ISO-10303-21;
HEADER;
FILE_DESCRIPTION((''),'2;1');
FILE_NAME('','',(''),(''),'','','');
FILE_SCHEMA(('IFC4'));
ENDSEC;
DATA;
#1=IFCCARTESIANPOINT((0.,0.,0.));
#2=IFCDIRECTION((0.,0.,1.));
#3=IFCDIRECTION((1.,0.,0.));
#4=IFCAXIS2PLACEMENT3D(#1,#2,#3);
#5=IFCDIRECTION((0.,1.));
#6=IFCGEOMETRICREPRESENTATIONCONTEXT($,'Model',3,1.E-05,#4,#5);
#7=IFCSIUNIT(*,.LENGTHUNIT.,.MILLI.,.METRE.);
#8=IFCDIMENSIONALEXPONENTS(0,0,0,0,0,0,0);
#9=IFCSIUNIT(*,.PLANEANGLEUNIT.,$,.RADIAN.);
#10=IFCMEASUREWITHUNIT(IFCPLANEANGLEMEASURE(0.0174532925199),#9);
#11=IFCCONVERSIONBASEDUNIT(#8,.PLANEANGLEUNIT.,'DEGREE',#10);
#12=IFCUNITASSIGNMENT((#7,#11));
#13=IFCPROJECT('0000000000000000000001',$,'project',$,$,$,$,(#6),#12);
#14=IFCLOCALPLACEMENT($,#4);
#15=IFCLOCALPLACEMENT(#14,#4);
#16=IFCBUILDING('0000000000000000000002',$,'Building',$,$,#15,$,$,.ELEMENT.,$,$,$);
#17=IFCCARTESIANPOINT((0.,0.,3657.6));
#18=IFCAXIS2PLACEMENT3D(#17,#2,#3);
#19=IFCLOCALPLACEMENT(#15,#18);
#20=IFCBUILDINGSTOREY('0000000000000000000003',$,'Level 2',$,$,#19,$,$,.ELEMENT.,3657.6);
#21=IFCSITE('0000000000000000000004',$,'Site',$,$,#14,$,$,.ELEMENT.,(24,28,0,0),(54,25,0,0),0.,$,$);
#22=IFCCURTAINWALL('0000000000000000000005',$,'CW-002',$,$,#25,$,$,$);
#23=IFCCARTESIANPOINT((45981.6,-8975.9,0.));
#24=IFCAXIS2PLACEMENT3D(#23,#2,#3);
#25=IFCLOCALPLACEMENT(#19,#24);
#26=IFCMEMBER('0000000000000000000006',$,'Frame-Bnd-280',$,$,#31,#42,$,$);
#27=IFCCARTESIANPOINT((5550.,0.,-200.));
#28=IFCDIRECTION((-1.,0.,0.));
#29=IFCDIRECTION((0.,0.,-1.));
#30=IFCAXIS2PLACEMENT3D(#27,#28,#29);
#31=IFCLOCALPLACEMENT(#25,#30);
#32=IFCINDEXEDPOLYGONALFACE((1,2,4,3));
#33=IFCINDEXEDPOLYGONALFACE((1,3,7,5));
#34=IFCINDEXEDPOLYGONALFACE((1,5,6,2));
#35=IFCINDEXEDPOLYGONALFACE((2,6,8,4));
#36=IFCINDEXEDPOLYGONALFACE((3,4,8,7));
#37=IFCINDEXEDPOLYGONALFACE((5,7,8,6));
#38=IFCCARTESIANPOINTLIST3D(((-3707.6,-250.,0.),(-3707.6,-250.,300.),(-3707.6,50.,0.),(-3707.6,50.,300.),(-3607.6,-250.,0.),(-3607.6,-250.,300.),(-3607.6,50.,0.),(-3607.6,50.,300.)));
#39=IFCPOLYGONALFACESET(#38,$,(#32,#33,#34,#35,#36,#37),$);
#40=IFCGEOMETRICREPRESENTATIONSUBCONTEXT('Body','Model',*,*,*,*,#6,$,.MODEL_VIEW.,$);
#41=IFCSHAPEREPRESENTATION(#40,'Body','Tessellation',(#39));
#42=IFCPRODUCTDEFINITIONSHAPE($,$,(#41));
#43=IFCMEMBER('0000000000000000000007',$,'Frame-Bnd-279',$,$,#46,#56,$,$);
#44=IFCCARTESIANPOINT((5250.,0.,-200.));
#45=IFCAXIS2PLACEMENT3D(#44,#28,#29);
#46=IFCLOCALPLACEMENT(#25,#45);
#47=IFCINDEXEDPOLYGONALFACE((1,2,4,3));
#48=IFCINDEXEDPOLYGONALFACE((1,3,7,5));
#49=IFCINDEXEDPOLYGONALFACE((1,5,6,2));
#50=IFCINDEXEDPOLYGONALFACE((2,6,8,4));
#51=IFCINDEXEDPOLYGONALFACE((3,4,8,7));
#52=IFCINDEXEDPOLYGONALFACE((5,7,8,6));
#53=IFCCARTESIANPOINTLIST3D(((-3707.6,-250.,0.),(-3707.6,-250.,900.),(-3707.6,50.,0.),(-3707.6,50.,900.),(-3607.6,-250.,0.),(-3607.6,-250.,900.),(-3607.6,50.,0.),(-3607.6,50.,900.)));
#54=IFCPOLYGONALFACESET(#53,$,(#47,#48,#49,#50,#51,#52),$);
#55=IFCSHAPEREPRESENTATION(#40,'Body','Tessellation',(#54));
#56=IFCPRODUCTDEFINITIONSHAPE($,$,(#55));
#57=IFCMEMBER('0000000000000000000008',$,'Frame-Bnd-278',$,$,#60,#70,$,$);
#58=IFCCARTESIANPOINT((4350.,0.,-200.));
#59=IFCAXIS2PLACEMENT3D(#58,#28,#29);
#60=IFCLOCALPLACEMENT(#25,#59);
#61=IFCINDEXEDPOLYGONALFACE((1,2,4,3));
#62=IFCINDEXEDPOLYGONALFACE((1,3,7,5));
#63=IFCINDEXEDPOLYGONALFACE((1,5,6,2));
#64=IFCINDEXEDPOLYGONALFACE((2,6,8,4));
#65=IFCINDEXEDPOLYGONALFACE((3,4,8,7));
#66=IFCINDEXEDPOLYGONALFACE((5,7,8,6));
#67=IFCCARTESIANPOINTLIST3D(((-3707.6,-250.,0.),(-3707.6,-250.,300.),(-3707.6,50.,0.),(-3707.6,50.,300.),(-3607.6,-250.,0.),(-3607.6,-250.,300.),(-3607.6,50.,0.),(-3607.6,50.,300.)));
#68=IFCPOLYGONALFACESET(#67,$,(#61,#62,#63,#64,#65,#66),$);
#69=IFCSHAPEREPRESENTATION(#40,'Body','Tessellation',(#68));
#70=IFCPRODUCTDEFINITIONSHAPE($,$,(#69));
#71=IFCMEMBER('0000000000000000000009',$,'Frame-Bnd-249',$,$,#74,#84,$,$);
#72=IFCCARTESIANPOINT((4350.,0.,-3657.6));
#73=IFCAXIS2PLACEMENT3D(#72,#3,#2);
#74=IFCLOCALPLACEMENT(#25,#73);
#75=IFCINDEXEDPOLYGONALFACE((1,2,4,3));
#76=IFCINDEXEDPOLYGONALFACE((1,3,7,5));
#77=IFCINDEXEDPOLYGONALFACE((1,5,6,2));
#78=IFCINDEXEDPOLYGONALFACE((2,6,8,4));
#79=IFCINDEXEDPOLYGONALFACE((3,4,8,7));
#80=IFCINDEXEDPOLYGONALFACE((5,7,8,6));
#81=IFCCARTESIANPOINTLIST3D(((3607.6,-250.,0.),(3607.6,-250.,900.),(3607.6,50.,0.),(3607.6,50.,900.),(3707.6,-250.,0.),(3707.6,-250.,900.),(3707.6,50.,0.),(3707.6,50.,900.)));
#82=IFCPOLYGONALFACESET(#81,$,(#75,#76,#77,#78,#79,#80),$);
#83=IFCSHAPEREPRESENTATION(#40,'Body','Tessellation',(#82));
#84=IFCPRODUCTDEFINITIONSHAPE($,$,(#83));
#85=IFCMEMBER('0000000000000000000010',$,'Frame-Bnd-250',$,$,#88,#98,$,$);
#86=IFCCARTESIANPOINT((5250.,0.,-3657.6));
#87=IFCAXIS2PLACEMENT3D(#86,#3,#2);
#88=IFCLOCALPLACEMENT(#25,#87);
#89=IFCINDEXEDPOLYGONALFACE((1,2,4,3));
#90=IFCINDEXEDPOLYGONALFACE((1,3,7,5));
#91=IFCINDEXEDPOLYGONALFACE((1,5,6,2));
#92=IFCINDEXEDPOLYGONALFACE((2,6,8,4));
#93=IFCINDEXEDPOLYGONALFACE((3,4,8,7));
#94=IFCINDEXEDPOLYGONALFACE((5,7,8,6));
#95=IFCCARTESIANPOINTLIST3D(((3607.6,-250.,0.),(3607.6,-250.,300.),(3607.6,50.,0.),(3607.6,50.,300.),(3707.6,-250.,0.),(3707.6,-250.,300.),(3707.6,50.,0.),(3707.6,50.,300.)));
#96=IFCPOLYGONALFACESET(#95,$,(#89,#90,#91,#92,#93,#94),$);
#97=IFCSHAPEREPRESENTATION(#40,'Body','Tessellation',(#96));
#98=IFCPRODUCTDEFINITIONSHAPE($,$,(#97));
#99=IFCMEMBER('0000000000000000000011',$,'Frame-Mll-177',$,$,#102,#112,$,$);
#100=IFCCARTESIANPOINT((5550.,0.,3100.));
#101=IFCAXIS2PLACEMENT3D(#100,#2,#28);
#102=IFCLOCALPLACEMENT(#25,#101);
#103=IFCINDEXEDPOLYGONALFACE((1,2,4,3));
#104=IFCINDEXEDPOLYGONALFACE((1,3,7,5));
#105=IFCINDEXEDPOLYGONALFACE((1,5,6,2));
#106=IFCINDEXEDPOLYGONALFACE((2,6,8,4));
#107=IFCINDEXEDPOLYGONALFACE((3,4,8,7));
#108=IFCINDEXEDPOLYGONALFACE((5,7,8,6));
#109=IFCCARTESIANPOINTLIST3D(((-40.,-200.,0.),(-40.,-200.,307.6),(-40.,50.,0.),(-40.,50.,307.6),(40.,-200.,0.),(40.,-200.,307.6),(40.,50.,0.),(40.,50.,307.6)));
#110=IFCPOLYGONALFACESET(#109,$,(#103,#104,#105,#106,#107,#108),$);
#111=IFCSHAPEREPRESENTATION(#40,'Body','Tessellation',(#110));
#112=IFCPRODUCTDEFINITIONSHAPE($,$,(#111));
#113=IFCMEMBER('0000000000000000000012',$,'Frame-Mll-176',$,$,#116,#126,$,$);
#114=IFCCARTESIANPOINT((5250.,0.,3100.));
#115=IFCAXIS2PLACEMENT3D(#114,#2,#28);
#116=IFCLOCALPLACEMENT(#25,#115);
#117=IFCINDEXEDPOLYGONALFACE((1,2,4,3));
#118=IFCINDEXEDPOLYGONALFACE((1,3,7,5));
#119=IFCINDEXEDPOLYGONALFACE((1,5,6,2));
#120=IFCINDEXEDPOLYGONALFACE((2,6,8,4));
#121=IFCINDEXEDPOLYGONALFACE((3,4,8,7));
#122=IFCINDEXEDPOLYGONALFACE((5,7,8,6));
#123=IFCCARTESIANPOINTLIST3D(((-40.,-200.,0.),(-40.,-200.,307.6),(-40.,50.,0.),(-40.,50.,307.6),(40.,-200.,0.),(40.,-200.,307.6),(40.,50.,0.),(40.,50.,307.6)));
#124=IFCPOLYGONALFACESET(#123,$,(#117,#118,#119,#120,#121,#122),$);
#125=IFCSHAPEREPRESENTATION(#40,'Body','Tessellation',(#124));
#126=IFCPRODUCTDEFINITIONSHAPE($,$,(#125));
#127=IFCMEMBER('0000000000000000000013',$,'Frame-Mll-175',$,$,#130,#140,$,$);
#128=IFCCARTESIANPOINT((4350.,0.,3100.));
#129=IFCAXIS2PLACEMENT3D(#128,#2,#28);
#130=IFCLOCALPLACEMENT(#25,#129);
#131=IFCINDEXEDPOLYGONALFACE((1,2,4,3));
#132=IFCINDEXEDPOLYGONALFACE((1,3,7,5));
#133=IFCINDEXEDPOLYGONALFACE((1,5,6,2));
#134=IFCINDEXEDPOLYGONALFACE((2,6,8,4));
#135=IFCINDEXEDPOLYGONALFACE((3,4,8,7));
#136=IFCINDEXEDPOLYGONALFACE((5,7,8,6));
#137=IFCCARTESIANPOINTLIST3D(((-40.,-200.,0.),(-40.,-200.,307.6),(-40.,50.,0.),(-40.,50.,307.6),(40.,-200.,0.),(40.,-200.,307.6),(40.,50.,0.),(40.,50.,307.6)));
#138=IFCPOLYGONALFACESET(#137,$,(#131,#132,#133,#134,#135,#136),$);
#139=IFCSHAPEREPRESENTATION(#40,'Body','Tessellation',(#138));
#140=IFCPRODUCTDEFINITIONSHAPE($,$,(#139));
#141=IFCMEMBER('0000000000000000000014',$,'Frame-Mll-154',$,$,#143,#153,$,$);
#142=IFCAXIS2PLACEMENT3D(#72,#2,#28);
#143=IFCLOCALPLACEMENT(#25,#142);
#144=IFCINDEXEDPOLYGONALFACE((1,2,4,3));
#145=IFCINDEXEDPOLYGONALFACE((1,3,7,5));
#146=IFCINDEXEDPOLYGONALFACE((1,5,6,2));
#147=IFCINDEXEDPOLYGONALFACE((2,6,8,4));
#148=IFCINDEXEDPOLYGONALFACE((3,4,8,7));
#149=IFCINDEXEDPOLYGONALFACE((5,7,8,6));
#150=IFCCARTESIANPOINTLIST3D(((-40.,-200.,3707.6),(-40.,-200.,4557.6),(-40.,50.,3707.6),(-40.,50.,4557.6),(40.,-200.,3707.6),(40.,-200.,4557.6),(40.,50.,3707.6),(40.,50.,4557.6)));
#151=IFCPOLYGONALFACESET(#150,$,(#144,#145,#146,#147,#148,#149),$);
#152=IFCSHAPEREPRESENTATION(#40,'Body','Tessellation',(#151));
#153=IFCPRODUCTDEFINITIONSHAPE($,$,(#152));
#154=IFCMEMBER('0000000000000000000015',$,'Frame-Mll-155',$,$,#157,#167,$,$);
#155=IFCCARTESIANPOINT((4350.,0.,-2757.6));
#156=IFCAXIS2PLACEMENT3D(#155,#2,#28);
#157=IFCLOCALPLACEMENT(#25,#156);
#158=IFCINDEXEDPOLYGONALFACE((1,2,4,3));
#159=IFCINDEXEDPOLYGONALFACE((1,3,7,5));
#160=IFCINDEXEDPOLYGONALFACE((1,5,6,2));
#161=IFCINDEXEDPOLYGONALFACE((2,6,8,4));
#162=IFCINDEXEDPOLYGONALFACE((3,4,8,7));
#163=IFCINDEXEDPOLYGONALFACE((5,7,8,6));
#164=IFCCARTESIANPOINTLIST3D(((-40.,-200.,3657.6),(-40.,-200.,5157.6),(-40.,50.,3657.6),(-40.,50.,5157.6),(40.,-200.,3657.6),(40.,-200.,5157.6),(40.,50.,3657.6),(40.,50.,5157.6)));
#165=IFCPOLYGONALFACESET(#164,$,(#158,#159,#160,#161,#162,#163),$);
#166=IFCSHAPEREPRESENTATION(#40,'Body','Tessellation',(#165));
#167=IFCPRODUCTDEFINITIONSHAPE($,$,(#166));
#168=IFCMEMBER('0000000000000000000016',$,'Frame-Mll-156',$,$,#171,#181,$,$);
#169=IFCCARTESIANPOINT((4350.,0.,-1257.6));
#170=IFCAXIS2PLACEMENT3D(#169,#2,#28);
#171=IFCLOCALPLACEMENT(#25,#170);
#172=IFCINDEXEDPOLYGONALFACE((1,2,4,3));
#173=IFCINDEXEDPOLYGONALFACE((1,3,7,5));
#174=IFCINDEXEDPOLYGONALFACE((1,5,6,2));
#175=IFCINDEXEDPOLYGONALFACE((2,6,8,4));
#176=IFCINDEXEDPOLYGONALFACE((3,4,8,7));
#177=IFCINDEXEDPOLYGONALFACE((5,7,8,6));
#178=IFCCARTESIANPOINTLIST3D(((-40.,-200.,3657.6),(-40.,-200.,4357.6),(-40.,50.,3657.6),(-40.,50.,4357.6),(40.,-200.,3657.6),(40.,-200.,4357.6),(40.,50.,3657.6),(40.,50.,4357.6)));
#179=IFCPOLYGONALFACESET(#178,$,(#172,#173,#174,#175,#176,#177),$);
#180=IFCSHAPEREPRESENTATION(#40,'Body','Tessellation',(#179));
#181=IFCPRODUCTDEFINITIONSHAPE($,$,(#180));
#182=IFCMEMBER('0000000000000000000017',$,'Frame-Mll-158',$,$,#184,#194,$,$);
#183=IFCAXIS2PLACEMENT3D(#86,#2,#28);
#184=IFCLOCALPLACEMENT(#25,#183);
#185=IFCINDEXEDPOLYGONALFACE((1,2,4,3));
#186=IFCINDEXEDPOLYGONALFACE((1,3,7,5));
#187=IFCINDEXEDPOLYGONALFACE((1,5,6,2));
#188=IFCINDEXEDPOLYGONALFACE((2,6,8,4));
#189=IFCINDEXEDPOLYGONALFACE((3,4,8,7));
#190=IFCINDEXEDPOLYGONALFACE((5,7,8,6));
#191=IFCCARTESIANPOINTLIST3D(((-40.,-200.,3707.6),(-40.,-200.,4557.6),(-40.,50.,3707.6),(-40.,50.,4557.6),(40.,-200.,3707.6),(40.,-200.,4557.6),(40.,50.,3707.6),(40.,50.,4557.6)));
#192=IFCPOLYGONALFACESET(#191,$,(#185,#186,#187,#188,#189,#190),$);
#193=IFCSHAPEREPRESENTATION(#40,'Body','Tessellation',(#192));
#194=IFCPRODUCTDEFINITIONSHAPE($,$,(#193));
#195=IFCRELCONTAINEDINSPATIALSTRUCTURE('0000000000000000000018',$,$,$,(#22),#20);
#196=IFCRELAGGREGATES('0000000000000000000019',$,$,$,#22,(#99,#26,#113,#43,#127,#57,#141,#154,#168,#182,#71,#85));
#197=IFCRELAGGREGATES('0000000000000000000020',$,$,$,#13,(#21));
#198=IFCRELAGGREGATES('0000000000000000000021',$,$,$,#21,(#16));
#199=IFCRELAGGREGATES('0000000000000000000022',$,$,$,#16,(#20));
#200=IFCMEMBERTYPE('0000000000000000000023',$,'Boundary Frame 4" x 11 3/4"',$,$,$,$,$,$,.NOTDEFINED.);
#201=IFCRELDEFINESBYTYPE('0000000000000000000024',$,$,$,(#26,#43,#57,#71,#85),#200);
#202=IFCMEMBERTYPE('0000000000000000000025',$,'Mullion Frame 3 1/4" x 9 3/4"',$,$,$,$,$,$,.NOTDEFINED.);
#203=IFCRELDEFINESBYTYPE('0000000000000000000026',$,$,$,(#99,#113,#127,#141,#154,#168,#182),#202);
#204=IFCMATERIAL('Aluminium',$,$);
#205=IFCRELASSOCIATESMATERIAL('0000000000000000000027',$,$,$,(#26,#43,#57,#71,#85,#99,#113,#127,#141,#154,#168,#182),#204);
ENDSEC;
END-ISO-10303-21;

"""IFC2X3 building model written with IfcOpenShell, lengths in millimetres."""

from ifc_helpers import new_model, entity, si_unit, converted_unit, direction, frame, origin_with_axes, place, context, subcontext, project, spatial, polyline, outline, extrude, material, type_object, element, aggregate, save


model = new_model("IFC2X3")

# Units and contexts
model_context = context("Model", 3, precision=1e-05, world=origin_with_axes(), true_north=direction((0.0, 1.0)))
body_context = subcontext(model_context, "Body", "Model", "MODEL_VIEW")
ifc_project = project(units=[si_unit("LENGTHUNIT", "METRE", prefix="MILLI"), converted_unit("PLANEANGLEUNIT", "DEGREE", entity("IfcPlaneAngleMeasure", 0.0174532925199), si_unit("PLANEANGLEUNIT", "RADIAN"), dimensions=[0, 0, 0, 0, 0, 0, 0])], contexts=[model_context])

# Site, building, storey
site_placement = place(None, origin_with_axes())
site = spatial("IfcSite", under=ifc_project, at=site_placement, Name="Site", CompositionType="ELEMENT", RefLatitude=(24, 28, 0, 0), RefLongitude=(54, 25, 0, 0), RefElevation=0.0)
building_placement = place(site_placement, origin_with_axes())
building = spatial("IfcBuilding", under=site, at=building_placement, Name="Building", CompositionType="ELEMENT")
storey_placement = place(building_placement, frame((0.0, 0.0, 3657.6), z_axis=(0.0, 0.0, 1.0), x_axis=(1.0, 0.0, 0.0)))
storey = spatial("IfcBuildingStorey", under=building, at=storey_placement, Name="Level 2", CompositionType="ELEMENT", Elevation=3657.6)

# Curtain wall, members
curtain_wall_placement = place(storey_placement, frame((45981.6, -8975.9, 0.0), z_axis=(0.0, 0.0, 1.0), x_axis=(1.0, 0.0, 0.0)))
curtain_wall = element("IfcCurtainWall", 1, at=curtain_wall_placement, inside=storey, Name="CW-002")
ifc_material_1 = material(Name="Aluminium")
member_type_1 = type_object("IfcMemberType", Name="Boundary Frame 4\" x 11 3/4\"", PredefinedType="NOTDEFINED")
member_1_placement = place(curtain_wall_placement, frame((5550.0, 0.0, -200.0), z_axis=(-1.0, 0.0, 0.0), x_axis=(0.0, 0.0, -1.0)))
member_1 = element("IfcMember", 2, at=member_1_placement, type_object=member_type_1, material=ifc_material_1, Name="Frame-Bnd-280", context=body_context, shape_type="SweptSolid", body=[
    extrude(outline(polyline([(250.0, -3607.6), (-50.0, -3607.6), (-50.0, -3707.6), (250.0, -3707.6), (250.0, -3607.6)])), frame((0.0, 0.0, 0.0), z_axis=(0.0, 0.0, 1.0), x_axis=(0.0, -1.0, 0.0)), (0.0, 0.0, 1.0), 300.0),
])
member_2_placement = place(curtain_wall_placement, frame((5250.0, 0.0, -200.0), z_axis=(-1.0, 0.0, 0.0), x_axis=(0.0, 0.0, -1.0)))
member_2 = element("IfcMember", 3, at=member_2_placement, type_object=member_type_1, material=ifc_material_1, Name="Frame-Bnd-279", context=body_context, shape_type="SweptSolid", body=[
    extrude(outline(polyline([(250.0, -3607.6), (-50.0, -3607.6), (-50.0, -3707.6), (250.0, -3707.6), (250.0, -3607.6)])), frame((0.0, 0.0, 0.0), z_axis=(0.0, 0.0, 1.0), x_axis=(0.0, -1.0, 0.0)), (0.0, 0.0, 1.0), 900.0),
])
member_3_placement = place(curtain_wall_placement, frame((4350.0, 0.0, -200.0), z_axis=(-1.0, 0.0, 0.0), x_axis=(0.0, 0.0, -1.0)))
member_3 = element("IfcMember", 4, at=member_3_placement, type_object=member_type_1, material=ifc_material_1, Name="Frame-Bnd-278", context=body_context, shape_type="SweptSolid", body=[
    extrude(outline(polyline([(250.0, -3607.6), (-50.0, -3607.6), (-50.0, -3707.6), (250.0, -3707.6), (250.0, -3607.6)])), frame((0.0, 0.0, 0.0), z_axis=(0.0, 0.0, 1.0), x_axis=(0.0, -1.0, 0.0)), (0.0, 0.0, 1.0), 300.0),
])
member_4_placement = place(curtain_wall_placement, frame((4350.0, 0.0, -3657.6), z_axis=(1.0, 0.0, 0.0), x_axis=(0.0, 0.0, 1.0)))
member_4 = element("IfcMember", 5, at=member_4_placement, type_object=member_type_1, material=ifc_material_1, Name="Frame-Bnd-249", context=body_context, shape_type="SweptSolid", body=[
    extrude(outline(polyline([(-250.0, -3707.6), (50.0, -3707.6), (50.0, -3607.6), (-250.0, -3607.6), (-250.0, -3707.6)])), frame((0.0, 0.0, 0.0), z_axis=(0.0, 0.0, 1.0), x_axis=(0.0, 1.0, 0.0)), (0.0, 0.0, 1.0), 900.0),
])
member_5_placement = place(curtain_wall_placement, frame((5250.0, 0.0, -3657.6), z_axis=(1.0, 0.0, 0.0), x_axis=(0.0, 0.0, 1.0)))
member_5 = element("IfcMember", 6, at=member_5_placement, type_object=member_type_1, material=ifc_material_1, Name="Frame-Bnd-250", context=body_context, shape_type="SweptSolid", body=[
    extrude(outline(polyline([(-250.0, -3707.6), (50.0, -3707.6), (50.0, -3607.6), (-250.0, -3607.6), (-250.0, -3707.6)])), frame((0.0, 0.0, 0.0), z_axis=(0.0, 0.0, 1.0), x_axis=(0.0, 1.0, 0.0)), (0.0, 0.0, 1.0), 300.0),
])
member_type_2 = type_object("IfcMemberType", Name="Mullion Frame 3 1/4\" x 9 3/4\"", PredefinedType="NOTDEFINED")
member_6_placement = place(curtain_wall_placement, frame((5550.0, 0.0, 3100.0), z_axis=(0.0, 0.0, 1.0), x_axis=(-1.0, 0.0, 0.0)))
member_6 = element("IfcMember", 7, at=member_6_placement, type_object=member_type_2, material=ifc_material_1, Name="Frame-Mll-177", context=body_context, shape_type="SweptSolid", body=[
    extrude(outline(polyline([(-40.0, 200.0), (-40.0, -50.0), (40.0, -50.0), (40.0, 200.0), (-40.0, 200.0)])), frame((0.0, 0.0, 0.0), z_axis=(0.0, 0.0, 1.0), x_axis=(-1.0, 0.0, 0.0)), (0.0, 0.0, 1.0), 307.6),
])
member_7_placement = place(curtain_wall_placement, frame((5250.0, 0.0, 3100.0), z_axis=(0.0, 0.0, 1.0), x_axis=(-1.0, 0.0, 0.0)))
member_7 = element("IfcMember", 8, at=member_7_placement, type_object=member_type_2, material=ifc_material_1, Name="Frame-Mll-176", context=body_context, shape_type="SweptSolid", body=[
    extrude(outline(polyline([(-40.0, 200.0), (-40.0, -50.0), (40.0, -50.0), (40.0, 200.0), (-40.0, 200.0)])), frame((0.0, 0.0, 0.0), z_axis=(0.0, 0.0, 1.0), x_axis=(-1.0, 0.0, 0.0)), (0.0, 0.0, 1.0), 307.6),
])
member_8_placement = place(curtain_wall_placement, frame((4350.0, 0.0, 3100.0), z_axis=(0.0, 0.0, 1.0), x_axis=(-1.0, 0.0, 0.0)))
member_8 = element("IfcMember", 9, at=member_8_placement, type_object=member_type_2, material=ifc_material_1, Name="Frame-Mll-175", context=body_context, shape_type="SweptSolid", body=[
    extrude(outline(polyline([(-40.0, 200.0), (-40.0, -50.0), (40.0, -50.0), (40.0, 200.0), (-40.0, 200.0)])), frame((0.0, 0.0, 0.0), z_axis=(0.0, 0.0, 1.0), x_axis=(-1.0, 0.0, 0.0)), (0.0, 0.0, 1.0), 307.6),
])
member_9_placement = place(curtain_wall_placement, frame((4350.0, 0.0, -3657.6), z_axis=(0.0, 0.0, 1.0), x_axis=(-1.0, 0.0, 0.0)))
member_9 = element("IfcMember", 10, at=member_9_placement, type_object=member_type_2, material=ifc_material_1, Name="Frame-Mll-154", context=body_context, shape_type="SweptSolid", body=[
    extrude(outline(polyline([(-40.0, 200.0), (-40.0, -50.0), (40.0, -50.0), (40.0, 200.0), (-40.0, 200.0)])), frame((0.0, 0.0, 3707.6), z_axis=(0.0, 0.0, 1.0), x_axis=(-1.0, 0.0, 0.0)), (0.0, 0.0, 1.0), 850.0),
])
member_10_placement = place(curtain_wall_placement, frame((4350.0, 0.0, -2757.6), z_axis=(0.0, 0.0, 1.0), x_axis=(-1.0, 0.0, 0.0)))
member_10 = element("IfcMember", 11, at=member_10_placement, type_object=member_type_2, material=ifc_material_1, Name="Frame-Mll-155", context=body_context, shape_type="SweptSolid", body=[
    extrude(outline(polyline([(-40.0, 200.0), (-40.0, -50.0), (40.0, -50.0), (40.0, 200.0), (-40.0, 200.0)])), frame((0.0, 0.0, 3657.6), z_axis=(0.0, 0.0, 1.0), x_axis=(-1.0, 0.0, 0.0)), (0.0, 0.0, 1.0), 1500.0),
])
member_11_placement = place(curtain_wall_placement, frame((4350.0, 0.0, -1257.6), z_axis=(0.0, 0.0, 1.0), x_axis=(-1.0, 0.0, 0.0)))
member_11 = element("IfcMember", 12, at=member_11_placement, type_object=member_type_2, material=ifc_material_1, Name="Frame-Mll-156", context=body_context, shape_type="SweptSolid", body=[
    extrude(outline(polyline([(-40.0, 200.0), (-40.0, -50.0), (40.0, -50.0), (40.0, 200.0), (-40.0, 200.0)])), frame((0.0, 0.0, 3657.6), z_axis=(0.0, 0.0, 1.0), x_axis=(-1.0, 0.0, 0.0)), (0.0, 0.0, 1.0), 700.0),
])
member_12_placement = place(curtain_wall_placement, frame((5250.0, 0.0, -3657.6), z_axis=(0.0, 0.0, 1.0), x_axis=(-1.0, 0.0, 0.0)))
member_12 = element("IfcMember", 13, at=member_12_placement, type_object=member_type_2, material=ifc_material_1, Name="Frame-Mll-158", context=body_context, shape_type="SweptSolid", body=[
    extrude(outline(polyline([(-40.0, 200.0), (-40.0, -50.0), (40.0, -50.0), (40.0, 200.0), (-40.0, 200.0)])), frame((0.0, 0.0, 3707.6), z_axis=(0.0, 0.0, 1.0), x_axis=(-1.0, 0.0, 0.0)), (0.0, 0.0, 1.0), 850.0),
])
aggregate(curtain_wall, [member_6, member_1, member_7, member_2, member_8, member_3, member_9, member_10, member_11, member_12, member_4, member_5])

save(model, "model.ifc")
